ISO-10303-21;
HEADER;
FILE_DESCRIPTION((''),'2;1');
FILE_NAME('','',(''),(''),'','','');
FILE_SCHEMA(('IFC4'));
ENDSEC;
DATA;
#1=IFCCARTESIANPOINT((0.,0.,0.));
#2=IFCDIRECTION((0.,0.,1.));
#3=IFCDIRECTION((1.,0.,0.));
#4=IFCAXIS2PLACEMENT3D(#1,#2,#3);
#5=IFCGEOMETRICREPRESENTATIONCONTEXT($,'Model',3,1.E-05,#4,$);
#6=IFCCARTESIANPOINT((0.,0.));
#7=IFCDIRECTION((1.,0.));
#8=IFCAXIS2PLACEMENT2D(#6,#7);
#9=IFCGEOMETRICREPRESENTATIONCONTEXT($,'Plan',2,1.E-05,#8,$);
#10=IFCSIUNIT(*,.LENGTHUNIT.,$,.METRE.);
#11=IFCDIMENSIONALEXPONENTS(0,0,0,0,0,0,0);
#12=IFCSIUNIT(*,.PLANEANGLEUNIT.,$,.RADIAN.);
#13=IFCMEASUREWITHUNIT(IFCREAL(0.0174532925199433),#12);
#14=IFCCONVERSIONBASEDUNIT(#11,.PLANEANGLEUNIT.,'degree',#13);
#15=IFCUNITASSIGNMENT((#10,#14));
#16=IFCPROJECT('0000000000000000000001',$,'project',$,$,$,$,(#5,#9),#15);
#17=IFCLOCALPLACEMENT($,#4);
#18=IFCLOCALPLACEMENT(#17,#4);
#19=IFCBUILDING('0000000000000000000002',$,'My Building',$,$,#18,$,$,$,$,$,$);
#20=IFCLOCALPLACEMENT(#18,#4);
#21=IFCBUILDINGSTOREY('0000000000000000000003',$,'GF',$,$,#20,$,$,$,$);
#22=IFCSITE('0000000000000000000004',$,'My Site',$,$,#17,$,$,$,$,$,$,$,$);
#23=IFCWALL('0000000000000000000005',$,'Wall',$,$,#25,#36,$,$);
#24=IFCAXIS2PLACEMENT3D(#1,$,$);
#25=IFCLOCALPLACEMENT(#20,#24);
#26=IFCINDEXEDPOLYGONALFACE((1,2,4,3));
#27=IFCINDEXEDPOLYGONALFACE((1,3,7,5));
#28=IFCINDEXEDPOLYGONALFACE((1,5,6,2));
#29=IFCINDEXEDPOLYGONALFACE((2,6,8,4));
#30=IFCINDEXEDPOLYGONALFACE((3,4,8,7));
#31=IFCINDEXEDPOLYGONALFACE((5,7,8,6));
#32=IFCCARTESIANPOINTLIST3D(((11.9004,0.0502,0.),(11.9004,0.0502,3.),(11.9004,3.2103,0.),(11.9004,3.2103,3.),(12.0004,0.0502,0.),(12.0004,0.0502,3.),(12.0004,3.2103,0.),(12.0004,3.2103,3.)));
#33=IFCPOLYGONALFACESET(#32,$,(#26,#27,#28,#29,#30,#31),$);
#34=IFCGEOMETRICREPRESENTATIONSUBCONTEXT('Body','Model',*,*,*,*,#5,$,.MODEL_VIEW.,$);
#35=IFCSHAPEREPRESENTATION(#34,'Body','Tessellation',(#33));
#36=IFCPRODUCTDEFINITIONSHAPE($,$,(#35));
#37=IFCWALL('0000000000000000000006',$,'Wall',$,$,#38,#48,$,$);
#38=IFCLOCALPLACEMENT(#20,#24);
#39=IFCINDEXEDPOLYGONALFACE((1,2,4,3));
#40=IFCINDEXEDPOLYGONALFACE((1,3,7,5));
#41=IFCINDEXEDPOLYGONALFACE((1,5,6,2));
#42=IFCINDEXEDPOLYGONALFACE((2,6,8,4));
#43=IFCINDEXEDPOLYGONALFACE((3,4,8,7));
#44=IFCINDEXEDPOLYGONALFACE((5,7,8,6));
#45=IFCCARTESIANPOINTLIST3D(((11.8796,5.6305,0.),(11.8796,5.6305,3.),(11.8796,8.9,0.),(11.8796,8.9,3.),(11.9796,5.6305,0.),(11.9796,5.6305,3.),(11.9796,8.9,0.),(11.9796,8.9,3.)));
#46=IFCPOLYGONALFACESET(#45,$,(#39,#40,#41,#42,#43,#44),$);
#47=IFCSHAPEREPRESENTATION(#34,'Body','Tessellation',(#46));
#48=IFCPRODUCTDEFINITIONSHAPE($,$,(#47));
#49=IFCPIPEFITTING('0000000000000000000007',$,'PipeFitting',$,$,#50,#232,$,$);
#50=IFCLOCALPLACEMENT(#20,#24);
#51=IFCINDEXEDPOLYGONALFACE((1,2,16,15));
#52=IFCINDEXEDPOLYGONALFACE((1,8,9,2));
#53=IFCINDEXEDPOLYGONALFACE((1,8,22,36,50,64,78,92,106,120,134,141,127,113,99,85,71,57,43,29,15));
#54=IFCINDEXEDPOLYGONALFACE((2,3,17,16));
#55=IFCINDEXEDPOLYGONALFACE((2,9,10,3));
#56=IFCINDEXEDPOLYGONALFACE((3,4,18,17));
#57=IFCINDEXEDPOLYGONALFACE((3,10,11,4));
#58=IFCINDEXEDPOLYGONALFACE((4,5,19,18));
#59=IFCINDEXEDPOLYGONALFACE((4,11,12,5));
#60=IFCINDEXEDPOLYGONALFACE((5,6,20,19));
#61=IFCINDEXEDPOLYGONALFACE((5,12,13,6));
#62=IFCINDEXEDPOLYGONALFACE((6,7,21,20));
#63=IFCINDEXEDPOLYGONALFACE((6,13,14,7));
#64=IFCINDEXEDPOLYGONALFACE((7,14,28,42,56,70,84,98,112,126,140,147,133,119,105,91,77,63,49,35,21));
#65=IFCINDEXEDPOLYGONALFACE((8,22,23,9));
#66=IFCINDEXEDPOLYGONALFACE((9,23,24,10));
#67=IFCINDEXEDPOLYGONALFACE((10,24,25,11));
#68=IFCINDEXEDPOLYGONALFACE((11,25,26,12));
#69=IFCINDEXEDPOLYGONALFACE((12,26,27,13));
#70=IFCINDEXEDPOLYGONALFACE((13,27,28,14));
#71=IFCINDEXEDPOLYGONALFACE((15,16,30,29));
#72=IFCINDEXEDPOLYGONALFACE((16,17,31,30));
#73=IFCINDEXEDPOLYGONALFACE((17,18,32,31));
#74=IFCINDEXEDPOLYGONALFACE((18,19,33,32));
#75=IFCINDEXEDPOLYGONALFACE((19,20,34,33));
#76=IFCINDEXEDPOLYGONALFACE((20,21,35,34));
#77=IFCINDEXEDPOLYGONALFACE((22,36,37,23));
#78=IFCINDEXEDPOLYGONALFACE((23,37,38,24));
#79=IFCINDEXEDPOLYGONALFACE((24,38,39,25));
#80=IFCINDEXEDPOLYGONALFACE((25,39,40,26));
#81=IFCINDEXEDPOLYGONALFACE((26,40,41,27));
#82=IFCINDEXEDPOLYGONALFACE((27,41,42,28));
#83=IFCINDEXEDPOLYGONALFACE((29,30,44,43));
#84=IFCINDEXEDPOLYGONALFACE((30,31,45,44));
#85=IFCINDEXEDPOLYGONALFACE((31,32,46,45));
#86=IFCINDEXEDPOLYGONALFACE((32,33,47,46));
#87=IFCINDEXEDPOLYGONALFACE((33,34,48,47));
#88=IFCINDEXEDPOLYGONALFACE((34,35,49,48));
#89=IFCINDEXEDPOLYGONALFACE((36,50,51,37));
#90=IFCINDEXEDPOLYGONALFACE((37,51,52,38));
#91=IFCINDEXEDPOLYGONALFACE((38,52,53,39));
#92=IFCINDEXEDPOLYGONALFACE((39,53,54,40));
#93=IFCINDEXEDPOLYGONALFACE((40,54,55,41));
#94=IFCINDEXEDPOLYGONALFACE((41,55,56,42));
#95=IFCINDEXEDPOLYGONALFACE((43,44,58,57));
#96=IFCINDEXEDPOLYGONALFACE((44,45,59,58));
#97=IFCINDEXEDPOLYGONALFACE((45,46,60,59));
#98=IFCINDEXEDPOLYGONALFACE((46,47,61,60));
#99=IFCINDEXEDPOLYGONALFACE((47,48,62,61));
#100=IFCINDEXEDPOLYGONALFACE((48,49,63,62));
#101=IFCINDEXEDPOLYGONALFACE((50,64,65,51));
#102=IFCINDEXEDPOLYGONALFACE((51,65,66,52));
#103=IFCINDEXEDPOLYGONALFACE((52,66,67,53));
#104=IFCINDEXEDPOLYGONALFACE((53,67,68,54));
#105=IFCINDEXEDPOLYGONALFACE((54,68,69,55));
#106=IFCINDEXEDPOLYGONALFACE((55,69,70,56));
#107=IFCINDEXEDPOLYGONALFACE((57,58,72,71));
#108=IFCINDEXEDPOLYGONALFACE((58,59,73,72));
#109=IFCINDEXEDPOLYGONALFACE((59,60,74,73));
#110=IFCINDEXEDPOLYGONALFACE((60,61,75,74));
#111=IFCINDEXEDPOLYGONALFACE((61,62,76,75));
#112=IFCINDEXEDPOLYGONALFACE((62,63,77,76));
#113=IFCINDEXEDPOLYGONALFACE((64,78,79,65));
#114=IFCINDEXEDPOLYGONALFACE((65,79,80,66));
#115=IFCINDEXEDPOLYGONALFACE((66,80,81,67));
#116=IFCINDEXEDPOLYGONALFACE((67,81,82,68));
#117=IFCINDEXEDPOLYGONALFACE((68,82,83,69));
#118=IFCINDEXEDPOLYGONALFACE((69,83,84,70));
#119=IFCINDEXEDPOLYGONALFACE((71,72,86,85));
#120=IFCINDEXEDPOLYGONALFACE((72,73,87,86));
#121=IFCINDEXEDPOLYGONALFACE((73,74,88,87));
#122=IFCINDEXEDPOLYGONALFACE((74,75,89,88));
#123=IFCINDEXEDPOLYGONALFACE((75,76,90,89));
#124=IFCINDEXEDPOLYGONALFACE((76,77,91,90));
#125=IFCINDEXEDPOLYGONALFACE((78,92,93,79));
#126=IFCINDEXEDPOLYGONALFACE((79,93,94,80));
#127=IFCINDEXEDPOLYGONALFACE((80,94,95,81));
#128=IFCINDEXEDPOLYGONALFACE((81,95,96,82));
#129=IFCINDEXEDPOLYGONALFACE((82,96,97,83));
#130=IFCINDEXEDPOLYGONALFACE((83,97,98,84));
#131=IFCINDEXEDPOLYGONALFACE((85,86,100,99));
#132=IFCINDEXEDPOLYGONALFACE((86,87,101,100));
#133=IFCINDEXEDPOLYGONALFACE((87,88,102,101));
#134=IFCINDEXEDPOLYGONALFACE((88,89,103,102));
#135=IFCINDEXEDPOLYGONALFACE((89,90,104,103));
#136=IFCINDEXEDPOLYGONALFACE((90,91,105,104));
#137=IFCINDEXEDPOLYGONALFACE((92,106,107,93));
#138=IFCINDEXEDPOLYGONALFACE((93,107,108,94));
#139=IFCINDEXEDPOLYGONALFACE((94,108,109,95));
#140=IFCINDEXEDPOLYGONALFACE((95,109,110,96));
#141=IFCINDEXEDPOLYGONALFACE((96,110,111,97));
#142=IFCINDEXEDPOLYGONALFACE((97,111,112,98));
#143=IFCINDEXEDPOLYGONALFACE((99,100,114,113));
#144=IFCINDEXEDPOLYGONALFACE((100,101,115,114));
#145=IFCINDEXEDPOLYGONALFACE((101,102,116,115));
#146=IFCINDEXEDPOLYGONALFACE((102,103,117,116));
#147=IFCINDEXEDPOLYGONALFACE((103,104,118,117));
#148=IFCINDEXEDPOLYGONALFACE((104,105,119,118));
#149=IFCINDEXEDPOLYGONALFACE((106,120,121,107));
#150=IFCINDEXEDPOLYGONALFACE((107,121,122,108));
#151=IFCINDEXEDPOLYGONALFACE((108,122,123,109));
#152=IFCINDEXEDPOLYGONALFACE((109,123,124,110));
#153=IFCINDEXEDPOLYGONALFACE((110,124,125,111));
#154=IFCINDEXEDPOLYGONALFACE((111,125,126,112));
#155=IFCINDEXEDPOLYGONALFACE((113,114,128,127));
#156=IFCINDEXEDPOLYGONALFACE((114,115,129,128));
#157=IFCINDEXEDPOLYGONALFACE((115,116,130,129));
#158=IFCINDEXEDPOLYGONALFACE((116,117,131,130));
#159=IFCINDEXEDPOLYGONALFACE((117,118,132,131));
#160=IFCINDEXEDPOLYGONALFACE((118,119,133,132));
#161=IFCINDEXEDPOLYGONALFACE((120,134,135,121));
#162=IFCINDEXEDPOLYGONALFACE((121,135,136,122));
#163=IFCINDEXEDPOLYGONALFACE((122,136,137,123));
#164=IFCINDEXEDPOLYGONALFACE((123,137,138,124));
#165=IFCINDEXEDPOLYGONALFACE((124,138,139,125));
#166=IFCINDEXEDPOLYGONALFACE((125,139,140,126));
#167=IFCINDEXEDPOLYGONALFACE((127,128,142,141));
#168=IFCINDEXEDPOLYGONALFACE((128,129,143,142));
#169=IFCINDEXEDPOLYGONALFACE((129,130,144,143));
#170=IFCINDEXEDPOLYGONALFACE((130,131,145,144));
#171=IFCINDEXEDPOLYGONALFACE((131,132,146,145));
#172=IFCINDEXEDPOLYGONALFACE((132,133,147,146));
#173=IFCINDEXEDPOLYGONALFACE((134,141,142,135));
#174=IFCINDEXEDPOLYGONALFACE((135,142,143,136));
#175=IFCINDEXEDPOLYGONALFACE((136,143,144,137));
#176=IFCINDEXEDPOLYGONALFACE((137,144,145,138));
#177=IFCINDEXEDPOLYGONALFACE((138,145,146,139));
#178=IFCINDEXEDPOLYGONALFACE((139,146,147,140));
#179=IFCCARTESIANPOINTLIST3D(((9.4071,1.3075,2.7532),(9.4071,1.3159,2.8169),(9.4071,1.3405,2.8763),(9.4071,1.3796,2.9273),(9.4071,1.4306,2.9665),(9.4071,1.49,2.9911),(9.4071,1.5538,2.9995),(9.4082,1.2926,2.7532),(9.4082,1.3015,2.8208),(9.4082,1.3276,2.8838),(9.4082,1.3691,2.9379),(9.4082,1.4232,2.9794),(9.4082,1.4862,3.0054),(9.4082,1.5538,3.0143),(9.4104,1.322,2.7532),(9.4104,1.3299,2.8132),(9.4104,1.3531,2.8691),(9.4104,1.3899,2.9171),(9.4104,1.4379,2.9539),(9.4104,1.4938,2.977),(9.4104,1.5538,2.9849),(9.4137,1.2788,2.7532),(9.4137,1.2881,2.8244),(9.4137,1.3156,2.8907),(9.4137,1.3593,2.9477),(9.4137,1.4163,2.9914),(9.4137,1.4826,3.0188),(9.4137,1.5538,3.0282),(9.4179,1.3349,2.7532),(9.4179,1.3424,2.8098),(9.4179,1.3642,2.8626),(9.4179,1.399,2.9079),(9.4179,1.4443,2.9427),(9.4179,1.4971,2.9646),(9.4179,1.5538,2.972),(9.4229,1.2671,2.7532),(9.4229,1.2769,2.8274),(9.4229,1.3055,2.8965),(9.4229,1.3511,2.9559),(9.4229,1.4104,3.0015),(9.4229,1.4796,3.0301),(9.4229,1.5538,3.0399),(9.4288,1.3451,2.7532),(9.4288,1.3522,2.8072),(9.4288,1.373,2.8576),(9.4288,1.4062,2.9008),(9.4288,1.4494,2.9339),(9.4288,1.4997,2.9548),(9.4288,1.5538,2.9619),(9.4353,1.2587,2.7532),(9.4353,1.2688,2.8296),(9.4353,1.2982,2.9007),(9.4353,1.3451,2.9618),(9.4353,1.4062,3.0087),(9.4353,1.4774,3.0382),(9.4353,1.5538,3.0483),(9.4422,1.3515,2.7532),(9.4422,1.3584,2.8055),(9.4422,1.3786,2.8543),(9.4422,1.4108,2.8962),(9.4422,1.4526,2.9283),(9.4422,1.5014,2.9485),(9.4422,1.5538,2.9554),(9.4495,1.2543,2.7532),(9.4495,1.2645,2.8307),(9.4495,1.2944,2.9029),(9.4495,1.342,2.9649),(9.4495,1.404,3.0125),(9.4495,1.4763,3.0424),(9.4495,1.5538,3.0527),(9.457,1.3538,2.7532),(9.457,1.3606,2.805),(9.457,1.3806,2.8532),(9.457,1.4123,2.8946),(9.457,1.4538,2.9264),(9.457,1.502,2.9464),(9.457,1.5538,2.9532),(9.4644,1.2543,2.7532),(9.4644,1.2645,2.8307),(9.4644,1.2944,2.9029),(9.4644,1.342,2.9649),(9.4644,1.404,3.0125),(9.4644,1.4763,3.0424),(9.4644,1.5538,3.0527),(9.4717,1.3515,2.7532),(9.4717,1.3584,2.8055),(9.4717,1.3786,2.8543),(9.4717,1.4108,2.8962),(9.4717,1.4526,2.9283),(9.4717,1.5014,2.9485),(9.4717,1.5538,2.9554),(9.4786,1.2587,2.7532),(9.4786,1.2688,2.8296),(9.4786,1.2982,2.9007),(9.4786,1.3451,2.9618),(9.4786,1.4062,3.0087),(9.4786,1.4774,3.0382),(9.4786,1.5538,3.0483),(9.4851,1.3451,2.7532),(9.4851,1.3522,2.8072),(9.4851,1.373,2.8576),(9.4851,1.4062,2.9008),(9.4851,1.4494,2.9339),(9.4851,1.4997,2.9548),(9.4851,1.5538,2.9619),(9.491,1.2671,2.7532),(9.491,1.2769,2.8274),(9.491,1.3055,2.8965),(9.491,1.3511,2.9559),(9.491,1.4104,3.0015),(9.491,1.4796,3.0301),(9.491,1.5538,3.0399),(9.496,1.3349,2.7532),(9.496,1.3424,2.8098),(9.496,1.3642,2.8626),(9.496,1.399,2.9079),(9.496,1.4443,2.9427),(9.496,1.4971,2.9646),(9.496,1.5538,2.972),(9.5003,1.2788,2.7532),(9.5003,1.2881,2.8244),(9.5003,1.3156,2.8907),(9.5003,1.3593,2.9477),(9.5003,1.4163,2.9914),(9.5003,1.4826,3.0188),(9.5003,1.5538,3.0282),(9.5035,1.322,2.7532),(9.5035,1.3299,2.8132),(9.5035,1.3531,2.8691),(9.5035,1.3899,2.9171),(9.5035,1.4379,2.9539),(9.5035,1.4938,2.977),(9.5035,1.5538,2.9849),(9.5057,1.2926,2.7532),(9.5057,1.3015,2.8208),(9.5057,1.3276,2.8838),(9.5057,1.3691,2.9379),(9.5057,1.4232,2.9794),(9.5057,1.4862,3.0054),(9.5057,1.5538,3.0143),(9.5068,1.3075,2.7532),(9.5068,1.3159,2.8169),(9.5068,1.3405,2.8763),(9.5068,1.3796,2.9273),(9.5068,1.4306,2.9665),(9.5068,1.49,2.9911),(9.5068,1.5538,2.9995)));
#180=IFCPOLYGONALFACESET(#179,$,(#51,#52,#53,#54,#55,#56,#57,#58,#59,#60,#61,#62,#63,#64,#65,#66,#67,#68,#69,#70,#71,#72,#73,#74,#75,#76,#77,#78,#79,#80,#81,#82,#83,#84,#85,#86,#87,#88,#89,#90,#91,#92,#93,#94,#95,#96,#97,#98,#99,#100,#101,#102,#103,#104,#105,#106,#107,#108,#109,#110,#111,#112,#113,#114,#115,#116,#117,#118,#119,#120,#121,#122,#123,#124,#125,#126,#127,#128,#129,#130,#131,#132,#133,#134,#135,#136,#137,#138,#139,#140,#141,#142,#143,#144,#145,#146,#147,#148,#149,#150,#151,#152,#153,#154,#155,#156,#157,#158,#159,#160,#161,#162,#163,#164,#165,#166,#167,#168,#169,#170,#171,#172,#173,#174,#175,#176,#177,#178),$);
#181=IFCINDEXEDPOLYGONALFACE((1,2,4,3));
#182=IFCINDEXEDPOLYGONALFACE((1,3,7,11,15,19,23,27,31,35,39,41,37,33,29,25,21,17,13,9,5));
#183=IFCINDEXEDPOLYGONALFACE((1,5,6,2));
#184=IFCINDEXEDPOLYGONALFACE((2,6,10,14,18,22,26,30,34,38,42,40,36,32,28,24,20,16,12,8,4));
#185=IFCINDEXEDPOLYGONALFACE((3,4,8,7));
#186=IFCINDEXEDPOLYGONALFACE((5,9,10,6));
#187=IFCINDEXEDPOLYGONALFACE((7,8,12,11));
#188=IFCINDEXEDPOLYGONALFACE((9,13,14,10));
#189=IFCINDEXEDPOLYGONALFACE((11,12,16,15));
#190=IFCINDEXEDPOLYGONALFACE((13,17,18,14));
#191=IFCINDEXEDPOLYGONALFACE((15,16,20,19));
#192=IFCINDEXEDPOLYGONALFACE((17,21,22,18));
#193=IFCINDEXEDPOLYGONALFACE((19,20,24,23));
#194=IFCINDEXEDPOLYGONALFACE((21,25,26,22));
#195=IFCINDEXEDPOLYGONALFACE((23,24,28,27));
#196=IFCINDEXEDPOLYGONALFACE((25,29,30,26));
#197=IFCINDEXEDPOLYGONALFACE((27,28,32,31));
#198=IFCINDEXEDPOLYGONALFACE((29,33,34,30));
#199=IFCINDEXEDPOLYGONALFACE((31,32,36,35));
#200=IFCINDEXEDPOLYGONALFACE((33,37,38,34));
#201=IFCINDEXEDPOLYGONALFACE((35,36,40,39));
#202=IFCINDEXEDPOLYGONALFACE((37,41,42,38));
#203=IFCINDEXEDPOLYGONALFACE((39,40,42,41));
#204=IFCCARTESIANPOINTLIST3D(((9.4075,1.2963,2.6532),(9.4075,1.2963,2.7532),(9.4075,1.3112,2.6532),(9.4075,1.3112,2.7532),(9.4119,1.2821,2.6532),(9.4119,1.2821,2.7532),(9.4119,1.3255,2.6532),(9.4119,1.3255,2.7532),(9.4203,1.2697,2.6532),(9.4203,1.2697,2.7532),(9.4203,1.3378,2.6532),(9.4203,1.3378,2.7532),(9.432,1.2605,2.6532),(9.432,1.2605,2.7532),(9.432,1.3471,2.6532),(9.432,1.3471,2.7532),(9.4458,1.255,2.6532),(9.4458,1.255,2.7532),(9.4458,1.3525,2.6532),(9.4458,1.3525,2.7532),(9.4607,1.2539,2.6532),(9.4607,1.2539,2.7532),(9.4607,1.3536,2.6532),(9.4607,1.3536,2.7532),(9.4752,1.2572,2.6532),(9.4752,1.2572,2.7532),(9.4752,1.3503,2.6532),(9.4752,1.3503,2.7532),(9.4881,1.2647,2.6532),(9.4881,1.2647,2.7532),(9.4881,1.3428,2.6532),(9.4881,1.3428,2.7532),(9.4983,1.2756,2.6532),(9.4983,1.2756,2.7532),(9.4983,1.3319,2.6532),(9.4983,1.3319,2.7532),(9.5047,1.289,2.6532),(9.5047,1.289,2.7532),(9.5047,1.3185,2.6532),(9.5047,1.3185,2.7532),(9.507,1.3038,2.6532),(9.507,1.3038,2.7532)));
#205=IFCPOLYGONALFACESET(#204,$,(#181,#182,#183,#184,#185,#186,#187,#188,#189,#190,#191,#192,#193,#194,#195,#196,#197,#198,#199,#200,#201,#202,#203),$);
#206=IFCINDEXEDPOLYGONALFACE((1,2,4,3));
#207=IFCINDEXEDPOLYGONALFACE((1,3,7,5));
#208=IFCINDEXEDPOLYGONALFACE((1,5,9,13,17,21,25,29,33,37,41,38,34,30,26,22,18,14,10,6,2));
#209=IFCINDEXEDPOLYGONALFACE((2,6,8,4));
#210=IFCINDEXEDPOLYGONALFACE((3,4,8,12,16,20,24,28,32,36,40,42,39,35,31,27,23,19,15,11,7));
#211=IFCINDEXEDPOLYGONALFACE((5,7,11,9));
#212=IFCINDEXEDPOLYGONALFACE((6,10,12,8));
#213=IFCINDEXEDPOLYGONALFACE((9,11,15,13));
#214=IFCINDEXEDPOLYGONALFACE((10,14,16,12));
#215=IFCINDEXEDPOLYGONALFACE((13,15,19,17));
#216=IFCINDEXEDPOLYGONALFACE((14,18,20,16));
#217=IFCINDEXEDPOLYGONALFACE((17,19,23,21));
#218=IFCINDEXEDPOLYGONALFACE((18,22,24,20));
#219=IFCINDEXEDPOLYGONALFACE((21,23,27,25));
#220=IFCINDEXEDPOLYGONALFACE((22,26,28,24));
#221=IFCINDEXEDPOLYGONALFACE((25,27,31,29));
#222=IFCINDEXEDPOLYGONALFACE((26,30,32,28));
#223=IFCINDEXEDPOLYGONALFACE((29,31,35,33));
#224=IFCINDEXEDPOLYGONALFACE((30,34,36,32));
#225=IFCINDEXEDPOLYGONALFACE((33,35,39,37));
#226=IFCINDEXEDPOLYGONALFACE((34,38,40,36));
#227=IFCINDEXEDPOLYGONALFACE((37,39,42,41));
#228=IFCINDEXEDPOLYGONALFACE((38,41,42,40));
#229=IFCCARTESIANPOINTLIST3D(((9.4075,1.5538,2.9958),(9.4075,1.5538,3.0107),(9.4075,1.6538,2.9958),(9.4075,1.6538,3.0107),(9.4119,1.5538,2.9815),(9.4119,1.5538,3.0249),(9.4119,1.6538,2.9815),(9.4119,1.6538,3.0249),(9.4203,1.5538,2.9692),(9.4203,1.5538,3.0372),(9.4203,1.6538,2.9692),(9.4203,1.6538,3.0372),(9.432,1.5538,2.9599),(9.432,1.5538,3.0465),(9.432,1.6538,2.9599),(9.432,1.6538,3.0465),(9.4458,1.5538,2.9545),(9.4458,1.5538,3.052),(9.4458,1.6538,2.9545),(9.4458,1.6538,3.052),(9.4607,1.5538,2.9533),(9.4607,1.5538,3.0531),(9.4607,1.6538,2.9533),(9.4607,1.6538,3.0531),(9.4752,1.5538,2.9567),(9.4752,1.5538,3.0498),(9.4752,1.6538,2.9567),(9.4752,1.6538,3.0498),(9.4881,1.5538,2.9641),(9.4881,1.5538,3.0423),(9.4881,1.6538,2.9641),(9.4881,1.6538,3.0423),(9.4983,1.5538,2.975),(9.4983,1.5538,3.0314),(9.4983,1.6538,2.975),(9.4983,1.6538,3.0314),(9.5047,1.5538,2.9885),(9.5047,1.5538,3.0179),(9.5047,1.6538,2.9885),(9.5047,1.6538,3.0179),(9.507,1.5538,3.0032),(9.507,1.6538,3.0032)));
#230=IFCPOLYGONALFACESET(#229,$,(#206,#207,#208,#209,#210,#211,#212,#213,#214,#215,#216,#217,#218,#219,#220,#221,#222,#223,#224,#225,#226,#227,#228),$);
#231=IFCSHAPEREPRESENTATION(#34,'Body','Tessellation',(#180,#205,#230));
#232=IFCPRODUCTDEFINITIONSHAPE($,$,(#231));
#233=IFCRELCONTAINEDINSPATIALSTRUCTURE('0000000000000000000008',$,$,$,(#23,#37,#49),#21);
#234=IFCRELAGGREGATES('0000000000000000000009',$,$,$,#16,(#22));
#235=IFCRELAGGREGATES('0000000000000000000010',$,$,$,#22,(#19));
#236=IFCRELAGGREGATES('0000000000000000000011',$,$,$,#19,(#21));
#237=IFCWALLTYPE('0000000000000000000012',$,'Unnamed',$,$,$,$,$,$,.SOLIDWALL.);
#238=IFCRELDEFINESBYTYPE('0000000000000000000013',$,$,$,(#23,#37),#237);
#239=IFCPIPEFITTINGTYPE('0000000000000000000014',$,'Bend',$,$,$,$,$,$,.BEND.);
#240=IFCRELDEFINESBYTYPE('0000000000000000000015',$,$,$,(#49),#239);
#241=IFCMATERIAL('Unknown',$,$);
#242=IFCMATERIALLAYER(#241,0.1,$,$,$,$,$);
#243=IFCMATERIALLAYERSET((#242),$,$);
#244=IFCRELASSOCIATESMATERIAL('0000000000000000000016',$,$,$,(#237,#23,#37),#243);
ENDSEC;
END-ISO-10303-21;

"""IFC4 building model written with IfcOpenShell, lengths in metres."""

from ifc_helpers import new_model, entity, si_unit, converted_unit, frame, origin_with_axes, origin_2d_with_axis, place, context, subcontext, project, spatial, line, indexed_curve, circle, outline, extrude, source, transform, mapped, material, layer, layer_set, layer_usage, type_object, type_shapes, element, save


model = new_model("IFC4")

# Units and contexts
model_context = context("Model", 3, precision=1e-05, world=origin_with_axes())
plan_context = context("Plan", 2, precision=1e-05, world=origin_2d_with_axis())
body_context_1 = subcontext(model_context, "Body", "Model", "MODEL_VIEW")
ifc_project = project(units=[si_unit("LENGTHUNIT", "METRE"), converted_unit("PLANEANGLEUNIT", "degree", entity("IfcReal", 0.0174532925199433), si_unit("PLANEANGLEUNIT", "RADIAN"), dimensions=[0, 0, 0, 0, 0, 0, 0])], contexts=[model_context, plan_context])

# Site, building, storey
site_placement = place(None, origin_with_axes())
site = spatial("IfcSite", under=ifc_project, at=site_placement, Name="My Site")
building_placement = place(site_placement, origin_with_axes())
building = spatial("IfcBuilding", under=site, at=building_placement, Name="My Building")
storey_placement = place(building_placement, origin_with_axes())
storey = spatial("IfcBuildingStorey", under=building, at=storey_placement, Name="GF")

# Shared definitions
ifc_material = material(Name="Unknown")
ifc_layer = layer(ifc_material, 0.1)
ifc_layer_set = layer_set([ifc_layer])
wall_type = type_object("IfcWallType", Name="Unnamed", PredefinedType="SOLIDWALL", material=ifc_layer_set)

# Walls
ifc_layer_usage_1 = layer_usage(ifc_layer_set, "AXIS2", "POSITIVE", 0.0)
wall_1_placement = place(storey_placement, frame((12.0004, 0.0502, 0.0), z_axis=(0.0, 0.0, 1.0), x_axis=(0.000013, 1.0, 0.0)))
element("IfcWall", 1, at=wall_1_placement, inside=storey, type_object=wall_type, material=ifc_layer_usage_1, Name="Wall", context=body_context_1, shape_type="SweptSolid", body=[
    extrude(outline(indexed_curve([(0.0, 0.0), (0.0, 0.1), (3.1602, 0.1), (3.1602, 0.0)], segments=[line(1, 2, 3, 4, 1)])), origin_with_axes(), (0.0, 0.0, 1.0), 3.0),
])
ifc_layer_usage_2 = layer_usage(ifc_layer_set, "AXIS2", "POSITIVE", 0.0)
wall_2_placement = place(storey_placement, frame((11.9796, 5.6305, 0.0), z_axis=(0.0, 0.0, 1.0), x_axis=(0.0, 1.0, 0.0)))
element("IfcWall", 2, at=wall_2_placement, inside=storey, type_object=wall_type, material=ifc_layer_usage_2, Name="Wall", context=body_context_1, shape_type="SweptSolid", body=[
    extrude(outline(indexed_curve([(0.0, 0.0), (0.0, 0.1), (3.2695, 0.1), (3.2695, 0.0)], segments=[line(1, 2, 3, 4, 1)])), origin_with_axes(), (0.0, 0.0, 1.0), 3.0),
])

# Pipe fitting
pipe_fitting_type = type_object("IfcPipeFittingType", Name="Bend", PredefinedType="BEND")
shared_shape_1 = source(origin_with_axes(), body_context_1, "Body", "SolidModel", [
    entity("IfcSweptDiskSolid", entity("IfcIndexedPolyCurve", entity("IfcCartesianPointList3D", [[0.0, 0.0, -0.1], [0.0, -0.0732, -0.2768], [0.0, -0.25, -0.35]]), [entity("IfcArcIndex", [1, 2, 3])]), 0.05),
    extrude(circle(Radius=0.05), origin_with_axes(), (0.0, 0.0, -1.0), 0.1),
    extrude(circle(Radius=0.05), frame((0.0, -0.25, -0.35), z_axis=(0.0, -1.0, 0.0), x_axis=(1.0, 0.0, 0.0)), (0.0, 0.0, 1.0), 0.1),
])
type_shapes(pipe_fitting_type, [shared_shape_1])
for number, where, z_axis, x_axis, name in (
    (3, (9.457, 1.3038, 2.6532), (0.0, 0.0, -1.0), (1.0, 0.0, 0.0), "PipeFitting"),
):
    element("IfcPipeFitting", number, at=place(storey_placement, frame(where, z_axis=z_axis, x_axis=x_axis)), inside=storey, type_object=pipe_fitting_type, Name=name, context=body_context_1, shape_type="MappedRepresentation", body=[
        mapped(shared_shape_1, transform((0.0, 0.0, 0.0), x_axis=(1.0, 0.0, 0.0), y_axis=(0.0, 1.0, 0.0), z_axis=(0.0, 0.0, 1.0), scale=1.0)),
    ])

save(model, "model.ifc")
